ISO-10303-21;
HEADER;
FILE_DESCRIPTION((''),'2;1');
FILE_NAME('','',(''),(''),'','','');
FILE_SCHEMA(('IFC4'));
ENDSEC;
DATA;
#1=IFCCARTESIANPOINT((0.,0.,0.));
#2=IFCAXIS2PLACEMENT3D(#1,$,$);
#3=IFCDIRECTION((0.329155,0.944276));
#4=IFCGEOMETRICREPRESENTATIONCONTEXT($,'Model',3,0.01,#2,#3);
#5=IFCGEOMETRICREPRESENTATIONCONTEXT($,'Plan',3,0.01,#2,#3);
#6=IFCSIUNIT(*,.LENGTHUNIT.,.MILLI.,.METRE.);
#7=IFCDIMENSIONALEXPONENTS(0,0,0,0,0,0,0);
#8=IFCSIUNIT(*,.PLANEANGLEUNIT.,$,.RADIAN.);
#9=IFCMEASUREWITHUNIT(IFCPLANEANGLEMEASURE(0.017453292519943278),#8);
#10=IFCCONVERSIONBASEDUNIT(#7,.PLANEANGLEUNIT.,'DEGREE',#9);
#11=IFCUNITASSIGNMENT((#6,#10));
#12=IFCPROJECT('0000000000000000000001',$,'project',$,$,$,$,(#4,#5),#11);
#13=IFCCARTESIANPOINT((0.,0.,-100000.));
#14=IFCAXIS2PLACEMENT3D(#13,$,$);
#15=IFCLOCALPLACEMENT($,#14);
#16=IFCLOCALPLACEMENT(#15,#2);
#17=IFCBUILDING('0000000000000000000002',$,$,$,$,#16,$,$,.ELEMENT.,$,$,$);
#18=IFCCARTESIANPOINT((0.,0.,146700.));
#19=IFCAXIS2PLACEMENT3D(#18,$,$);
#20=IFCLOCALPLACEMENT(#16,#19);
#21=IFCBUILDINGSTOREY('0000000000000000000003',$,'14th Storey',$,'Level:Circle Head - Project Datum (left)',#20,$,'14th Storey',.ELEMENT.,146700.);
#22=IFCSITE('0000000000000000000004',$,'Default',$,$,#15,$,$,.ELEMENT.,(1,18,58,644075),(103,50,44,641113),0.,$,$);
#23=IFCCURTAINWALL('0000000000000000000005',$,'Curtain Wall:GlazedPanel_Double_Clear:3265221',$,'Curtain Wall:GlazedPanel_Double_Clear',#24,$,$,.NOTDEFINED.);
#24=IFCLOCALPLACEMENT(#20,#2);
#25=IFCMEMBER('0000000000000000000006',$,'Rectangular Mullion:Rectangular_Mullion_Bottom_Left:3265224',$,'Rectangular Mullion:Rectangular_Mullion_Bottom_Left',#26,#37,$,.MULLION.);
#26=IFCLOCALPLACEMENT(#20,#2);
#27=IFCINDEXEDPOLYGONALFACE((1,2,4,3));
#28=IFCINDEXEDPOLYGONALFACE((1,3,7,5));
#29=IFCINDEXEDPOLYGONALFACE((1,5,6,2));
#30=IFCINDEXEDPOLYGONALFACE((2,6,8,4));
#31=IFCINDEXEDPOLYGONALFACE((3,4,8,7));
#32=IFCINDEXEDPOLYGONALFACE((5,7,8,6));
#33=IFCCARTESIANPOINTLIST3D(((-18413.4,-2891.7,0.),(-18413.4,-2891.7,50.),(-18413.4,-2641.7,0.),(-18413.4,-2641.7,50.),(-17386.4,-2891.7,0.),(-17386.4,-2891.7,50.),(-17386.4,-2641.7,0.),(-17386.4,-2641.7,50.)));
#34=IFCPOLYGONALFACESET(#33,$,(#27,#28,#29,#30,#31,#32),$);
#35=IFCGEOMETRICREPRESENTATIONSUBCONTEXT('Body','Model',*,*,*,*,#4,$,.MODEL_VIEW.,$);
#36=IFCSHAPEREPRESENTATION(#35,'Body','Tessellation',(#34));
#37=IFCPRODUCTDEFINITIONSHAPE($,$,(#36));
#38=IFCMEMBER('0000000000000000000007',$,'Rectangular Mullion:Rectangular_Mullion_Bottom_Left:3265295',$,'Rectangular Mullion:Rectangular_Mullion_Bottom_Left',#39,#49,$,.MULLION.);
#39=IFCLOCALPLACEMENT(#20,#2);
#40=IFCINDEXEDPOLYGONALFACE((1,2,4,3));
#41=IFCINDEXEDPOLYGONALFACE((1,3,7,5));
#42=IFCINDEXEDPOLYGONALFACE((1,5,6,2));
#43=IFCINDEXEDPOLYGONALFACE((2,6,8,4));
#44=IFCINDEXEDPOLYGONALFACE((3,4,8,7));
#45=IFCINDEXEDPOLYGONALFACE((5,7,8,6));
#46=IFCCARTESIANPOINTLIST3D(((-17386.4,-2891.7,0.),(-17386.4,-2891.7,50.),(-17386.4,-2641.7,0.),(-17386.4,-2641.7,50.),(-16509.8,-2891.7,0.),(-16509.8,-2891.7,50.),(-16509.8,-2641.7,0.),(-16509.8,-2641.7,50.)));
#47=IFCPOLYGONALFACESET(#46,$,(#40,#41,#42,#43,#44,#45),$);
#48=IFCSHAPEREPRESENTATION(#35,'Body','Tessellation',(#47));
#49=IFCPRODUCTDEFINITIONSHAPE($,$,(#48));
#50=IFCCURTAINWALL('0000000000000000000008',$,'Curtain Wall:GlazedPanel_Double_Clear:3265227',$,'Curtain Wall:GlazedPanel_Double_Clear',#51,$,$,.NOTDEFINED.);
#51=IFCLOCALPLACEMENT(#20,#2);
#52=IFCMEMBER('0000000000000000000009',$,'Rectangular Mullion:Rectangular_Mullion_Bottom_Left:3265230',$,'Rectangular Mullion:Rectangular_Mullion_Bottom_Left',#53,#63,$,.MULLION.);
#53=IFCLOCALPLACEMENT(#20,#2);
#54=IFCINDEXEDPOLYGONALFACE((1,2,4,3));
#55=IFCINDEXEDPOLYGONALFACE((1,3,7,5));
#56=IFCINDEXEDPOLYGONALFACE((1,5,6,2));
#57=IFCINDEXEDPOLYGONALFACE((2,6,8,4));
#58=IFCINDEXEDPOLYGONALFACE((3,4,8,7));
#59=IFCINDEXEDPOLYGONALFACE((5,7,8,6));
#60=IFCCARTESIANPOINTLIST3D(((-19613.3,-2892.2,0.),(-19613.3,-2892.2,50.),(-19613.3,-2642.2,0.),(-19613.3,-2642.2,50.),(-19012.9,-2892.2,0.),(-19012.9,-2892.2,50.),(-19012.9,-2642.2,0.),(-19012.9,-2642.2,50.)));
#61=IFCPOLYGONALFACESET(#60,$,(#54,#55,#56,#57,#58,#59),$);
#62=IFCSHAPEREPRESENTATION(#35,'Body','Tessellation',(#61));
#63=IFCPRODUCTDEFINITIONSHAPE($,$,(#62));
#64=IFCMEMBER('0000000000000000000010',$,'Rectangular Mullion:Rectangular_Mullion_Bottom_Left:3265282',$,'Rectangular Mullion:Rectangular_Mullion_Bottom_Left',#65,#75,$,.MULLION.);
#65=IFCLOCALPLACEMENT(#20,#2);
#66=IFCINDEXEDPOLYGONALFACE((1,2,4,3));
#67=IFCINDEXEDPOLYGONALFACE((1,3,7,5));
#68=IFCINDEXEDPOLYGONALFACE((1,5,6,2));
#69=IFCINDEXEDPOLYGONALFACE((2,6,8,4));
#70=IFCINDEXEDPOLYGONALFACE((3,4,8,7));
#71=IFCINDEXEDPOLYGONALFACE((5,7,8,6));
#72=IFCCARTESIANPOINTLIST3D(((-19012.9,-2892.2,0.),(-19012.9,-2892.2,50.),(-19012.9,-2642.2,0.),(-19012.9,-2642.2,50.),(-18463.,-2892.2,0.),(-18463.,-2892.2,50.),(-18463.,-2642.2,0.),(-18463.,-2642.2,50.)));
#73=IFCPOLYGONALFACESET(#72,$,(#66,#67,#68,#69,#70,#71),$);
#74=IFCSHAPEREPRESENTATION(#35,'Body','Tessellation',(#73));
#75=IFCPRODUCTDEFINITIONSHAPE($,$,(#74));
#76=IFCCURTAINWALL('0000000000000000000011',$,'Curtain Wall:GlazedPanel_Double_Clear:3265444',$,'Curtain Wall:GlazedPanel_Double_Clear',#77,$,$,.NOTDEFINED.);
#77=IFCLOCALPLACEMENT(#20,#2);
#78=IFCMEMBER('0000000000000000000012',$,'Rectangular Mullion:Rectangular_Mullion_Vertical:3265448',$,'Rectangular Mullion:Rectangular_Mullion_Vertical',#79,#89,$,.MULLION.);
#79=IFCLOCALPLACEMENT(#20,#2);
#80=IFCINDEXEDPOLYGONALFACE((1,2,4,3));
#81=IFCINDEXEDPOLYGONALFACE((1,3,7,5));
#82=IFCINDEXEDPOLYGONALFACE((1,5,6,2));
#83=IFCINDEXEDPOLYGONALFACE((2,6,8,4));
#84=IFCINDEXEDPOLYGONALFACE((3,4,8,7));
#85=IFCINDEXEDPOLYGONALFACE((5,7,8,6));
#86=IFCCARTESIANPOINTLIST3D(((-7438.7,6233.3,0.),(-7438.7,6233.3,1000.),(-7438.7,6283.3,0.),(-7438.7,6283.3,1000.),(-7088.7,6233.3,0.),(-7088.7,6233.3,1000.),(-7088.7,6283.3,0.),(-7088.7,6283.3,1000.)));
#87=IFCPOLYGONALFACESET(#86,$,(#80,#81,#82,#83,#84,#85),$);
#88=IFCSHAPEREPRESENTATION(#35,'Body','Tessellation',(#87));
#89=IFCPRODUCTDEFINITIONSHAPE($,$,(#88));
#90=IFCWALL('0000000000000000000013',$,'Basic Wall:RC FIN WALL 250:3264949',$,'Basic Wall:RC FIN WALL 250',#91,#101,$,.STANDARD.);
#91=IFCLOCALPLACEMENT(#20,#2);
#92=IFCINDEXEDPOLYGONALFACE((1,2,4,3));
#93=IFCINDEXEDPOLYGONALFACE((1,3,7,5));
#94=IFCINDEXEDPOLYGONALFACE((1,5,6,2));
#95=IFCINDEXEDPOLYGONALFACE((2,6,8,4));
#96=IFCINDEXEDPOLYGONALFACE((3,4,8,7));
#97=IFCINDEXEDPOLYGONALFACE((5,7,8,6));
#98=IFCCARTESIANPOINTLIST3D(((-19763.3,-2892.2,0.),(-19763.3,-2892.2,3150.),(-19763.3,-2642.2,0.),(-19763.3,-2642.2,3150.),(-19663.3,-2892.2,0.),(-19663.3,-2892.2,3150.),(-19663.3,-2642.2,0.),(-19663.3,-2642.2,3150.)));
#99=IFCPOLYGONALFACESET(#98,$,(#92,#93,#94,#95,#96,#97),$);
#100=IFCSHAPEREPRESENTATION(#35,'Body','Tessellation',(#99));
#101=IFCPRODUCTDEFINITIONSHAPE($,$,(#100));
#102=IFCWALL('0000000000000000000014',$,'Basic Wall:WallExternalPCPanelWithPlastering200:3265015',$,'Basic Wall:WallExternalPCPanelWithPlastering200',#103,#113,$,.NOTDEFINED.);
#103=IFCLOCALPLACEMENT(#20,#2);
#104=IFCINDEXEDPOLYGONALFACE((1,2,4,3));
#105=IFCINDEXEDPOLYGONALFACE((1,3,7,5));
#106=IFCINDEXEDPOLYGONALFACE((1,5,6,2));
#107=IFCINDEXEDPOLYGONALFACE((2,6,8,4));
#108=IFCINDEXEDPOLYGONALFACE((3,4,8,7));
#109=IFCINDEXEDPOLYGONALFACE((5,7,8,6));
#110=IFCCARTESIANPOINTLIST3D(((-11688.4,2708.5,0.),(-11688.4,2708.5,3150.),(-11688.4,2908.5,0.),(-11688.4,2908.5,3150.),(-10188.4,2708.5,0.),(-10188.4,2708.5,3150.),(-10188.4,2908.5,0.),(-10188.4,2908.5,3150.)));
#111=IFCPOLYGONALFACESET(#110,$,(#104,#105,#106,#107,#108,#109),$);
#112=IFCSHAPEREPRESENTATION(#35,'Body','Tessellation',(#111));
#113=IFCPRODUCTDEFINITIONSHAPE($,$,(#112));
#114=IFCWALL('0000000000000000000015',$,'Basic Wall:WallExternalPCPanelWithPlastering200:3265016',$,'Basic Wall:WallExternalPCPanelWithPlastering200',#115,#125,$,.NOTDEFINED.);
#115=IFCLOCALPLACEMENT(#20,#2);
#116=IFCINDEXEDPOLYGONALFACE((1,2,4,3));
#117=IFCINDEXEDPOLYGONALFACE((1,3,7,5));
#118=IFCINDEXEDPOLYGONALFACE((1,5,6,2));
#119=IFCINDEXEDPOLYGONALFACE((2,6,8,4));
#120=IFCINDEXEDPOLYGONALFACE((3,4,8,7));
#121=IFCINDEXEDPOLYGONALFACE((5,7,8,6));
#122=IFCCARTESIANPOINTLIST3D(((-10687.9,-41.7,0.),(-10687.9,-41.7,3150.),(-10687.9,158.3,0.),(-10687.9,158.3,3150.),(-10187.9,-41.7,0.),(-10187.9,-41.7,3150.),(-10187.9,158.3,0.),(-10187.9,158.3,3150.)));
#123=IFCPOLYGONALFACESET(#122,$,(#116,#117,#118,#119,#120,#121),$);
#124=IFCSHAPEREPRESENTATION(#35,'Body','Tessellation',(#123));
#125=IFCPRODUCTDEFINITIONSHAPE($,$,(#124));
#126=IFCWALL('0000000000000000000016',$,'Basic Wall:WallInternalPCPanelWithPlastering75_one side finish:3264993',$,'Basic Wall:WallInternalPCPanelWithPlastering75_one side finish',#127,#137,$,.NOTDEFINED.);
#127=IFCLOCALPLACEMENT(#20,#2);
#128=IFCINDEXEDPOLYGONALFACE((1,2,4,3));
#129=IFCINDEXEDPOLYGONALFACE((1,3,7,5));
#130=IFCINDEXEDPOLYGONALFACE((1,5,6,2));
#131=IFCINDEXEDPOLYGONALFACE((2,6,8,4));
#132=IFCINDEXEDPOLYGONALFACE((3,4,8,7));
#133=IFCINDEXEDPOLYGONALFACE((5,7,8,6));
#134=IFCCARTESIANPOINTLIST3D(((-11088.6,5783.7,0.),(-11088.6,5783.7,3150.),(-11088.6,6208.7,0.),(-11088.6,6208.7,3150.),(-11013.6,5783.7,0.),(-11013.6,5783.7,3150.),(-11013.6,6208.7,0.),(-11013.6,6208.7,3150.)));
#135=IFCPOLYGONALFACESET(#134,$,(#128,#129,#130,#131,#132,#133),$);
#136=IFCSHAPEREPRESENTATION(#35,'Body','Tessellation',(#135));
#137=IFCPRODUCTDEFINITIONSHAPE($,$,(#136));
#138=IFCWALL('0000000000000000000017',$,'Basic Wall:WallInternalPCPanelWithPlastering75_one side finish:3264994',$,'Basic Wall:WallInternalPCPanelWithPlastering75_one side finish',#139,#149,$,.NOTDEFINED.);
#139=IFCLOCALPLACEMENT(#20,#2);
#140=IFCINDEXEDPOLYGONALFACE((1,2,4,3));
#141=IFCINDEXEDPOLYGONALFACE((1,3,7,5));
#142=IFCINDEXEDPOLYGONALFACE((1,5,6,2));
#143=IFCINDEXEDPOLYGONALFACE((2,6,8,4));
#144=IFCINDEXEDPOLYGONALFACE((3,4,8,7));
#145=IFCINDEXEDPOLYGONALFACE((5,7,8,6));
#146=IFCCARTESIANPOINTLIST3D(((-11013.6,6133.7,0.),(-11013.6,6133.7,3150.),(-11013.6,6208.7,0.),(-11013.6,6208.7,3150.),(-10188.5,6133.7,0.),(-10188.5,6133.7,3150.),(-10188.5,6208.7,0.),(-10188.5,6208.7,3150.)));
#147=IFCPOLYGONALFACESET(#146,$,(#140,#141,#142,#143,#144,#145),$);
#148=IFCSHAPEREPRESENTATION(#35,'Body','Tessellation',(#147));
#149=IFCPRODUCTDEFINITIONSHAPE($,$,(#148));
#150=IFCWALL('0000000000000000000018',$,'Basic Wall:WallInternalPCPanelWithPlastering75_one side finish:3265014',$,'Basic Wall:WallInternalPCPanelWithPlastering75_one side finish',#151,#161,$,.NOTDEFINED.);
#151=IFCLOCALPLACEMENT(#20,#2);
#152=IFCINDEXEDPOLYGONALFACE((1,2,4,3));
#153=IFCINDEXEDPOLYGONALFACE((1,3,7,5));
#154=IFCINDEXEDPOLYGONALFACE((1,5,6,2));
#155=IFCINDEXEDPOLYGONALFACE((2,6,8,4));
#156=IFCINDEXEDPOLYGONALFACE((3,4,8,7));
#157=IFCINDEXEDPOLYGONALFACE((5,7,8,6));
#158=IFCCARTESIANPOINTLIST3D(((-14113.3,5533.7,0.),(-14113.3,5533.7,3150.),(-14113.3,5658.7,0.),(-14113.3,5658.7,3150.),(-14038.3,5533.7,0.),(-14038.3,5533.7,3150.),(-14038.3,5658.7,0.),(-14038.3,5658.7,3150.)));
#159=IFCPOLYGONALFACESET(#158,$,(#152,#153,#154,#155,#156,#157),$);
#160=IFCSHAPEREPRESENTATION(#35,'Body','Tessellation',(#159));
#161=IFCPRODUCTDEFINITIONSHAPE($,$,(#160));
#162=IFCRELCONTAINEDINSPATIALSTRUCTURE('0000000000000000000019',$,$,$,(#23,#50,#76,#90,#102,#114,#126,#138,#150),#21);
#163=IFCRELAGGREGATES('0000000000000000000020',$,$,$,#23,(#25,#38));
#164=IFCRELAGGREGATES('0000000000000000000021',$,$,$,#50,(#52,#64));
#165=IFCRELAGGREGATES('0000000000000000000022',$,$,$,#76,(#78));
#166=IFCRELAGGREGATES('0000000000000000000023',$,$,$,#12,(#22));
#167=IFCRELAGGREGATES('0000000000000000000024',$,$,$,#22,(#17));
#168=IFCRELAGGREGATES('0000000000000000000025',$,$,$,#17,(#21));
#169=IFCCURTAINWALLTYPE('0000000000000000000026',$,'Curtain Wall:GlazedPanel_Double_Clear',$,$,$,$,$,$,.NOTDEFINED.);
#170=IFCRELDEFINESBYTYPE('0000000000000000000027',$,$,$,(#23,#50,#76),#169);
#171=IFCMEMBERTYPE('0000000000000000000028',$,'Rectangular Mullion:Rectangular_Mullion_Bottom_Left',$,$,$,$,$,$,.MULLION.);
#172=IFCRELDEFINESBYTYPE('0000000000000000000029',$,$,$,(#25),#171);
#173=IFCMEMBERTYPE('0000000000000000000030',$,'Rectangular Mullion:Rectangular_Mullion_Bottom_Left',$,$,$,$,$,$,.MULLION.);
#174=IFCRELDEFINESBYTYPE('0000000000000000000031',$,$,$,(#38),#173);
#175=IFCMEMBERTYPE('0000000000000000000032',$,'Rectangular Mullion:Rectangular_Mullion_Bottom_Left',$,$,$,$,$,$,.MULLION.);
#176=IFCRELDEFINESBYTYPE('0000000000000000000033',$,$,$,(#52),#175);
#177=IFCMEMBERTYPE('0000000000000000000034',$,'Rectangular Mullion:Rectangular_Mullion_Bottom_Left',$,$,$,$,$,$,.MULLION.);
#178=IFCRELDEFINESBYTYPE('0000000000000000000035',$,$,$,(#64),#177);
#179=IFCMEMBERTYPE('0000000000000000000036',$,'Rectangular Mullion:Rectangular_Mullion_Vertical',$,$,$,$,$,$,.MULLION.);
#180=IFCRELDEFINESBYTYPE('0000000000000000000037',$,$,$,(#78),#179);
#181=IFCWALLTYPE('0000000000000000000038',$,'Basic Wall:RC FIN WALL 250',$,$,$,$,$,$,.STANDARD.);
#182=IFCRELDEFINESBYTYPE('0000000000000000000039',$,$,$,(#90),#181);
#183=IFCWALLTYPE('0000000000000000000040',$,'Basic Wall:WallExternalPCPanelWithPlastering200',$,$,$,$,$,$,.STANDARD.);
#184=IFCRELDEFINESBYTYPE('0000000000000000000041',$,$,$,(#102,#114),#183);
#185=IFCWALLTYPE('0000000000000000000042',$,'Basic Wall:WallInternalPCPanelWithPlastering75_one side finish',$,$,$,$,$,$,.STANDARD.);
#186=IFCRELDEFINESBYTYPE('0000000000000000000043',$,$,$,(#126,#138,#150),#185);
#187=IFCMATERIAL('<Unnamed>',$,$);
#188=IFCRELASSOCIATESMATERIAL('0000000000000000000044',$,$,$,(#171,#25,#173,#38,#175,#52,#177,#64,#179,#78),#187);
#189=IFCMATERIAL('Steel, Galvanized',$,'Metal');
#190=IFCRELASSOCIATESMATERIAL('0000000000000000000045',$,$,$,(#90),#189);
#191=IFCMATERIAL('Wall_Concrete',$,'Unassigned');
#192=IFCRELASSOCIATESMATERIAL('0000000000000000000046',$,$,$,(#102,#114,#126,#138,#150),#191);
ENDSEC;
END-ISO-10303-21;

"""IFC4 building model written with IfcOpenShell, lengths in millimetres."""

from ifc_helpers import new_model, entity, si_unit, converted_unit, direction, frame, origin, place, context, subcontext, project, spatial, indexed_curve, outline, extrude, source, transform, mapped, material, type_object, type_shapes, element, aggregate, save


model = new_model("IFC4")

# Units and contexts
model_context = context("Model", 3, precision=0.01, world=origin(), true_north=direction((0.329155, 0.944276)))
plan_context = context("Plan", 3, precision=0.01, world=origin(), true_north=direction((0.329155, 0.944276)))
body_context = subcontext(model_context, "Body", "Model", "MODEL_VIEW")
ifc_project = project(units=[si_unit("LENGTHUNIT", "METRE", prefix="MILLI"), converted_unit("PLANEANGLEUNIT", "DEGREE", entity("IfcPlaneAngleMeasure", 0.017453292519943278), si_unit("PLANEANGLEUNIT", "RADIAN"), dimensions=[0, 0, 0, 0, 0, 0, 0])], contexts=[model_context, plan_context])

# Site, building, storey
site_placement = place(None, frame((0.0, 0.0, -100000.0)))
site = spatial("IfcSite", under=ifc_project, at=site_placement, Name="Default", CompositionType="ELEMENT", RefLatitude=(1, 18, 58, 644075), RefLongitude=(103, 50, 44, 641113), RefElevation=0.0)
building_placement = place(site_placement, origin())
building = spatial("IfcBuilding", under=site, at=building_placement, CompositionType="ELEMENT")
storey_placement = place(building_placement, frame((0.0, 0.0, 146700.0)))
storey = spatial("IfcBuildingStorey", under=building, at=storey_placement, Name="14th Storey", ObjectType="Level:Circle Head - Project Datum (left)", LongName="14th Storey", CompositionType="ELEMENT", Elevation=146700.0)

# Curtain walls, members
curtain_wall_type = type_object("IfcCurtainWallType", Name="Curtain Wall:GlazedPanel_Double_Clear", PredefinedType="NOTDEFINED")
curtain_wall_1_placement = place(storey_placement, frame((0.0, 0.0, -146700.0)))
curtain_wall_1 = element("IfcCurtainWall", 1, at=curtain_wall_1_placement, inside=storey, type_object=curtain_wall_type, Name="Curtain Wall:GlazedPanel_Double_Clear:3265221", ObjectType="Curtain Wall:GlazedPanel_Double_Clear", PredefinedType="NOTDEFINED")
ifc_material_1 = material(Name="<Unnamed>")
member_type_1 = type_object("IfcMemberType", Name="Rectangular Mullion:Rectangular_Mullion_Bottom_Left", PredefinedType="MULLION", material=ifc_material_1)
shared_shape_1 = source(origin(), body_context, "Body", "SweptSolid", [
    extrude(outline(indexed_curve([(-25.0, -125.0), (25.0, -125.0), (25.0, 125.0), (-25.0, 125.0), (-25.0, -125.0)], self_intersect=False)), frame((-25.0, 0.0, -1027.0), z_axis=(0.0, 0.0, 1.0), x_axis=(-1.0, 0.0, 0.0)), (0.0, 0.0, 1.0), 1027.0),
])
type_shapes(member_type_1, [shared_shape_1])
member_1_placement = place(curtain_wall_1_placement, frame((-18413.4, -2766.7, 146700.0), z_axis=(-1.0, 0.0, 0.0), x_axis=(0.0, 0.0, -1.0)))
member_1 = element("IfcMember", 2, at=member_1_placement, type_object=member_type_1, material=ifc_material_1, Name="Rectangular Mullion:Rectangular_Mullion_Bottom_Left:3265224", ObjectType="Rectangular Mullion:Rectangular_Mullion_Bottom_Left", PredefinedType="MULLION", context=body_context, shape_type="MappedRepresentation", body=[
    mapped(shared_shape_1, transform((0.0, 0.0, 0.0), scale=1.0)),
])
member_type_2 = type_object("IfcMemberType", Name="Rectangular Mullion:Rectangular_Mullion_Bottom_Left", PredefinedType="MULLION", material=ifc_material_1)
shared_shape_2 = source(origin(), body_context, "Body", "SweptSolid", [
    extrude(outline(indexed_curve([(-25.0, -125.0), (25.0, -125.0), (25.0, 125.0), (-25.0, 125.0), (-25.0, -125.0)], self_intersect=False)), frame((-25.0, 0.0, -876.6), z_axis=(0.0, 0.0, 1.0), x_axis=(-1.0, 0.0, 0.0)), (0.0, 0.0, 1.0), 876.6),
])
type_shapes(member_type_2, [shared_shape_2])
member_2_placement = place(curtain_wall_1_placement, frame((-17386.4, -2766.7, 146700.0), z_axis=(-1.0, 0.0, 0.0), x_axis=(0.0, 0.0, -1.0)))
member_2 = element("IfcMember", 3, at=member_2_placement, type_object=member_type_2, material=ifc_material_1, Name="Rectangular Mullion:Rectangular_Mullion_Bottom_Left:3265295", ObjectType="Rectangular Mullion:Rectangular_Mullion_Bottom_Left", PredefinedType="MULLION", context=body_context, shape_type="MappedRepresentation", body=[
    mapped(shared_shape_2, transform((0.0, 0.0, 0.0), scale=1.0)),
])
aggregate(curtain_wall_1, [member_1, member_2])
curtain_wall_2_placement = place(storey_placement, frame((0.0, 0.0, -146700.0)))
curtain_wall_2 = element("IfcCurtainWall", 4, at=curtain_wall_2_placement, inside=storey, type_object=curtain_wall_type, Name="Curtain Wall:GlazedPanel_Double_Clear:3265227", ObjectType="Curtain Wall:GlazedPanel_Double_Clear", PredefinedType="NOTDEFINED")
member_type_3 = type_object("IfcMemberType", Name="Rectangular Mullion:Rectangular_Mullion_Bottom_Left", PredefinedType="MULLION", material=ifc_material_1)
shared_shape_3 = source(origin(), body_context, "Body", "SweptSolid", [
    extrude(outline(indexed_curve([(-25.0, -125.0), (25.0, -125.0), (25.0, 125.0), (-25.0, 125.0), (-25.0, -125.0)], self_intersect=False)), frame((-25.0, 0.0, -600.4), z_axis=(0.0, 0.0, 1.0), x_axis=(-1.0, 0.0, 0.0)), (0.0, 0.0, 1.0), 600.4),
])
type_shapes(member_type_3, [shared_shape_3])
member_3_placement = place(curtain_wall_2_placement, frame((-19613.3, -2767.2, 146700.0), z_axis=(-1.0, 0.0, 0.0), x_axis=(0.0, 0.0, -1.0)))
member_3 = element("IfcMember", 5, at=member_3_placement, type_object=member_type_3, material=ifc_material_1, Name="Rectangular Mullion:Rectangular_Mullion_Bottom_Left:3265230", ObjectType="Rectangular Mullion:Rectangular_Mullion_Bottom_Left", PredefinedType="MULLION", context=body_context, shape_type="MappedRepresentation", body=[
    mapped(shared_shape_3, transform((0.0, 0.0, 0.0), scale=1.0)),
])
member_type_4 = type_object("IfcMemberType", Name="Rectangular Mullion:Rectangular_Mullion_Bottom_Left", PredefinedType="MULLION", material=ifc_material_1)
shared_shape_4 = source(origin(), body_context, "Body", "SweptSolid", [
    extrude(outline(indexed_curve([(-25.0, -125.0), (25.0, -125.0), (25.0, 125.0), (-25.0, 125.0), (-25.0, -125.0)], self_intersect=False)), frame((-25.0, 0.0, -549.9), z_axis=(0.0, 0.0, 1.0), x_axis=(-1.0, 0.0, 0.0)), (0.0, 0.0, 1.0), 549.9),
])
type_shapes(member_type_4, [shared_shape_4])
member_4_placement = place(curtain_wall_2_placement, frame((-19012.9, -2767.2, 146700.0), z_axis=(-1.0, 0.0, 0.0), x_axis=(0.0, 0.0, -1.0)))
member_4 = element("IfcMember", 6, at=member_4_placement, type_object=member_type_4, material=ifc_material_1, Name="Rectangular Mullion:Rectangular_Mullion_Bottom_Left:3265282", ObjectType="Rectangular Mullion:Rectangular_Mullion_Bottom_Left", PredefinedType="MULLION", context=body_context, shape_type="MappedRepresentation", body=[
    mapped(shared_shape_4, transform((0.0, 0.0, 0.0), scale=1.0)),
])
aggregate(curtain_wall_2, [member_3, member_4])

# Curtain wall, member
curtain_wall_3_placement = place(storey_placement, frame((0.0, 0.0, -146700.0)))
curtain_wall_3 = element("IfcCurtainWall", 7, at=curtain_wall_3_placement, inside=storey, type_object=curtain_wall_type, Name="Curtain Wall:GlazedPanel_Double_Clear:3265444", ObjectType="Curtain Wall:GlazedPanel_Double_Clear", PredefinedType="NOTDEFINED")
member_type_5 = type_object("IfcMemberType", Name="Rectangular Mullion:Rectangular_Mullion_Vertical", PredefinedType="MULLION", material=ifc_material_1)
shared_shape_5 = source(origin(), body_context, "Body", "SweptSolid", [
    extrude(outline(indexed_curve([(-25.0, -175.0), (25.0, -175.0), (25.0, 175.0), (-25.0, 175.0), (-25.0, -175.0)], self_intersect=False)), frame((-25.0, -50.0, -1000.0), z_axis=(0.0, 0.0, 1.0), x_axis=(-1.0, 0.0, 0.0)), (0.0, 0.0, 1.0), 1000.0),
])
type_shapes(member_type_5, [shared_shape_5])
member_5_placement = place(curtain_wall_3_placement, frame((-7313.7, 6233.3, 146700.0), z_axis=(0.0, 0.0, -1.0), x_axis=(0.0, -1.0, 0.0)))
member_5 = element("IfcMember", 8, at=member_5_placement, type_object=member_type_5, material=ifc_material_1, Name="Rectangular Mullion:Rectangular_Mullion_Vertical:3265448", ObjectType="Rectangular Mullion:Rectangular_Mullion_Vertical", PredefinedType="MULLION", context=body_context, shape_type="MappedRepresentation", body=[
    mapped(shared_shape_5, transform((0.0, 0.0, 0.0), scale=1.0)),
])
aggregate(curtain_wall_3, [member_5])

# Walls
ifc_material_2 = material(Name="Steel, Galvanized", Category="Metal")
wall_type_1 = type_object("IfcWallType", Name="Basic Wall:RC FIN WALL 250", PredefinedType="STANDARD")
wall_1_placement = place(storey_placement, frame((-19763.3, -2767.2, 0.0)))
element("IfcWall", 9, at=wall_1_placement, inside=storey, type_object=wall_type_1, material=ifc_material_2, Name="Basic Wall:RC FIN WALL 250:3264949", ObjectType="Basic Wall:RC FIN WALL 250", PredefinedType="STANDARD", context=body_context, shape_type="SweptSolid", body=[
    extrude(outline(indexed_curve([(100.0, 125.0), (0.0, 125.0), (0.0, -125.0), (100.0, -125.0), (100.0, 125.0)], self_intersect=False)), origin(), (0.0, 0.0, 1.0), 3150.0),
])
ifc_material_3 = material(Name="Wall_Concrete", Category="Unassigned")
wall_type_2 = type_object("IfcWallType", Name="Basic Wall:WallExternalPCPanelWithPlastering200", PredefinedType="STANDARD")
wall_2_placement = place(storey_placement, frame((-10188.4, 2808.5, 0.0), z_axis=(0.0, 0.0, 1.0), x_axis=(-1.0, 0.0, 0.0)))
element("IfcWall", 10, at=wall_2_placement, inside=storey, type_object=wall_type_2, material=ifc_material_3, Name="Basic Wall:WallExternalPCPanelWithPlastering200:3265015", ObjectType="Basic Wall:WallExternalPCPanelWithPlastering200", PredefinedType="NOTDEFINED", context=body_context, shape_type="SweptSolid", body=[
    extrude(outline(indexed_curve([(1500.0, 100.0), (0.0, 100.0), (0.0, -100.0), (1500.0, -100.0), (1500.0, 100.0)], self_intersect=False)), origin(), (0.0, 0.0, 1.0), 3150.0),
])
wall_3_placement = place(storey_placement, frame((-10187.9, 58.3, 0.0), z_axis=(0.0, 0.0, 1.0), x_axis=(-1.0, 0.0, 0.0)))
element("IfcWall", 11, at=wall_3_placement, inside=storey, type_object=wall_type_2, material=ifc_material_3, Name="Basic Wall:WallExternalPCPanelWithPlastering200:3265016", ObjectType="Basic Wall:WallExternalPCPanelWithPlastering200", PredefinedType="NOTDEFINED", context=body_context, shape_type="SweptSolid", body=[
    extrude(outline(indexed_curve([(500.0, 100.0), (0.0, 100.0), (0.0, -100.0), (500.0, -100.0), (500.0, 100.0)], self_intersect=False)), origin(), (0.0, 0.0, 1.0), 3150.0),
])
wall_type_3 = type_object("IfcWallType", Name="Basic Wall:WallInternalPCPanelWithPlastering75_one side finish", PredefinedType="STANDARD")
wall_4_placement = place(storey_placement, frame((-11051.1, 5783.7, 0.0), z_axis=(0.0, 0.0, 1.0), x_axis=(0.0, 1.0, 0.0)))
element("IfcWall", 12, at=wall_4_placement, inside=storey, type_object=wall_type_3, material=ifc_material_3, Name="Basic Wall:WallInternalPCPanelWithPlastering75_one side finish:3264993", ObjectType="Basic Wall:WallInternalPCPanelWithPlastering75_one side finish", PredefinedType="NOTDEFINED", context=body_context, shape_type="SweptSolid", body=[
    extrude(outline(indexed_curve([(425.0, 37.5), (0.0, 37.5), (0.0, -37.5), (425.0, -37.5), (425.0, 37.5)], self_intersect=False)), origin(), (0.0, 0.0, 1.0), 3150.0),
])
wall_5_placement = place(storey_placement, frame((-11013.6, 6171.2, 0.0)))
element("IfcWall", 13, at=wall_5_placement, inside=storey, type_object=wall_type_3, material=ifc_material_3, Name="Basic Wall:WallInternalPCPanelWithPlastering75_one side finish:3264994", ObjectType="Basic Wall:WallInternalPCPanelWithPlastering75_one side finish", PredefinedType="NOTDEFINED", context=body_context, shape_type="SweptSolid", body=[
    extrude(outline(indexed_curve([(825.1, 37.5), (0.0, 37.5), (0.0, -37.5), (825.1, -37.5), (825.1, 37.5)], self_intersect=False)), origin(), (0.0, 0.0, 1.0), 3150.0),
])
wall_6_placement = place(storey_placement, frame((-14075.8, 5533.7, 0.0), z_axis=(0.0, 0.0, 1.0), x_axis=(0.0, 1.0, 0.0)))
element("IfcWall", 14, at=wall_6_placement, inside=storey, type_object=wall_type_3, material=ifc_material_3, Name="Basic Wall:WallInternalPCPanelWithPlastering75_one side finish:3265014", ObjectType="Basic Wall:WallInternalPCPanelWithPlastering75_one side finish", PredefinedType="NOTDEFINED", context=body_context, shape_type="SweptSolid", body=[
    extrude(outline(indexed_curve([(125.0, 37.5), (0.0, 37.5), (0.0, -37.5), (125.0, -37.5), (125.0, 37.5)], self_intersect=False)), origin(), (0.0, 0.0, 1.0), 3150.0),
])

save(model, "model.ifc")
